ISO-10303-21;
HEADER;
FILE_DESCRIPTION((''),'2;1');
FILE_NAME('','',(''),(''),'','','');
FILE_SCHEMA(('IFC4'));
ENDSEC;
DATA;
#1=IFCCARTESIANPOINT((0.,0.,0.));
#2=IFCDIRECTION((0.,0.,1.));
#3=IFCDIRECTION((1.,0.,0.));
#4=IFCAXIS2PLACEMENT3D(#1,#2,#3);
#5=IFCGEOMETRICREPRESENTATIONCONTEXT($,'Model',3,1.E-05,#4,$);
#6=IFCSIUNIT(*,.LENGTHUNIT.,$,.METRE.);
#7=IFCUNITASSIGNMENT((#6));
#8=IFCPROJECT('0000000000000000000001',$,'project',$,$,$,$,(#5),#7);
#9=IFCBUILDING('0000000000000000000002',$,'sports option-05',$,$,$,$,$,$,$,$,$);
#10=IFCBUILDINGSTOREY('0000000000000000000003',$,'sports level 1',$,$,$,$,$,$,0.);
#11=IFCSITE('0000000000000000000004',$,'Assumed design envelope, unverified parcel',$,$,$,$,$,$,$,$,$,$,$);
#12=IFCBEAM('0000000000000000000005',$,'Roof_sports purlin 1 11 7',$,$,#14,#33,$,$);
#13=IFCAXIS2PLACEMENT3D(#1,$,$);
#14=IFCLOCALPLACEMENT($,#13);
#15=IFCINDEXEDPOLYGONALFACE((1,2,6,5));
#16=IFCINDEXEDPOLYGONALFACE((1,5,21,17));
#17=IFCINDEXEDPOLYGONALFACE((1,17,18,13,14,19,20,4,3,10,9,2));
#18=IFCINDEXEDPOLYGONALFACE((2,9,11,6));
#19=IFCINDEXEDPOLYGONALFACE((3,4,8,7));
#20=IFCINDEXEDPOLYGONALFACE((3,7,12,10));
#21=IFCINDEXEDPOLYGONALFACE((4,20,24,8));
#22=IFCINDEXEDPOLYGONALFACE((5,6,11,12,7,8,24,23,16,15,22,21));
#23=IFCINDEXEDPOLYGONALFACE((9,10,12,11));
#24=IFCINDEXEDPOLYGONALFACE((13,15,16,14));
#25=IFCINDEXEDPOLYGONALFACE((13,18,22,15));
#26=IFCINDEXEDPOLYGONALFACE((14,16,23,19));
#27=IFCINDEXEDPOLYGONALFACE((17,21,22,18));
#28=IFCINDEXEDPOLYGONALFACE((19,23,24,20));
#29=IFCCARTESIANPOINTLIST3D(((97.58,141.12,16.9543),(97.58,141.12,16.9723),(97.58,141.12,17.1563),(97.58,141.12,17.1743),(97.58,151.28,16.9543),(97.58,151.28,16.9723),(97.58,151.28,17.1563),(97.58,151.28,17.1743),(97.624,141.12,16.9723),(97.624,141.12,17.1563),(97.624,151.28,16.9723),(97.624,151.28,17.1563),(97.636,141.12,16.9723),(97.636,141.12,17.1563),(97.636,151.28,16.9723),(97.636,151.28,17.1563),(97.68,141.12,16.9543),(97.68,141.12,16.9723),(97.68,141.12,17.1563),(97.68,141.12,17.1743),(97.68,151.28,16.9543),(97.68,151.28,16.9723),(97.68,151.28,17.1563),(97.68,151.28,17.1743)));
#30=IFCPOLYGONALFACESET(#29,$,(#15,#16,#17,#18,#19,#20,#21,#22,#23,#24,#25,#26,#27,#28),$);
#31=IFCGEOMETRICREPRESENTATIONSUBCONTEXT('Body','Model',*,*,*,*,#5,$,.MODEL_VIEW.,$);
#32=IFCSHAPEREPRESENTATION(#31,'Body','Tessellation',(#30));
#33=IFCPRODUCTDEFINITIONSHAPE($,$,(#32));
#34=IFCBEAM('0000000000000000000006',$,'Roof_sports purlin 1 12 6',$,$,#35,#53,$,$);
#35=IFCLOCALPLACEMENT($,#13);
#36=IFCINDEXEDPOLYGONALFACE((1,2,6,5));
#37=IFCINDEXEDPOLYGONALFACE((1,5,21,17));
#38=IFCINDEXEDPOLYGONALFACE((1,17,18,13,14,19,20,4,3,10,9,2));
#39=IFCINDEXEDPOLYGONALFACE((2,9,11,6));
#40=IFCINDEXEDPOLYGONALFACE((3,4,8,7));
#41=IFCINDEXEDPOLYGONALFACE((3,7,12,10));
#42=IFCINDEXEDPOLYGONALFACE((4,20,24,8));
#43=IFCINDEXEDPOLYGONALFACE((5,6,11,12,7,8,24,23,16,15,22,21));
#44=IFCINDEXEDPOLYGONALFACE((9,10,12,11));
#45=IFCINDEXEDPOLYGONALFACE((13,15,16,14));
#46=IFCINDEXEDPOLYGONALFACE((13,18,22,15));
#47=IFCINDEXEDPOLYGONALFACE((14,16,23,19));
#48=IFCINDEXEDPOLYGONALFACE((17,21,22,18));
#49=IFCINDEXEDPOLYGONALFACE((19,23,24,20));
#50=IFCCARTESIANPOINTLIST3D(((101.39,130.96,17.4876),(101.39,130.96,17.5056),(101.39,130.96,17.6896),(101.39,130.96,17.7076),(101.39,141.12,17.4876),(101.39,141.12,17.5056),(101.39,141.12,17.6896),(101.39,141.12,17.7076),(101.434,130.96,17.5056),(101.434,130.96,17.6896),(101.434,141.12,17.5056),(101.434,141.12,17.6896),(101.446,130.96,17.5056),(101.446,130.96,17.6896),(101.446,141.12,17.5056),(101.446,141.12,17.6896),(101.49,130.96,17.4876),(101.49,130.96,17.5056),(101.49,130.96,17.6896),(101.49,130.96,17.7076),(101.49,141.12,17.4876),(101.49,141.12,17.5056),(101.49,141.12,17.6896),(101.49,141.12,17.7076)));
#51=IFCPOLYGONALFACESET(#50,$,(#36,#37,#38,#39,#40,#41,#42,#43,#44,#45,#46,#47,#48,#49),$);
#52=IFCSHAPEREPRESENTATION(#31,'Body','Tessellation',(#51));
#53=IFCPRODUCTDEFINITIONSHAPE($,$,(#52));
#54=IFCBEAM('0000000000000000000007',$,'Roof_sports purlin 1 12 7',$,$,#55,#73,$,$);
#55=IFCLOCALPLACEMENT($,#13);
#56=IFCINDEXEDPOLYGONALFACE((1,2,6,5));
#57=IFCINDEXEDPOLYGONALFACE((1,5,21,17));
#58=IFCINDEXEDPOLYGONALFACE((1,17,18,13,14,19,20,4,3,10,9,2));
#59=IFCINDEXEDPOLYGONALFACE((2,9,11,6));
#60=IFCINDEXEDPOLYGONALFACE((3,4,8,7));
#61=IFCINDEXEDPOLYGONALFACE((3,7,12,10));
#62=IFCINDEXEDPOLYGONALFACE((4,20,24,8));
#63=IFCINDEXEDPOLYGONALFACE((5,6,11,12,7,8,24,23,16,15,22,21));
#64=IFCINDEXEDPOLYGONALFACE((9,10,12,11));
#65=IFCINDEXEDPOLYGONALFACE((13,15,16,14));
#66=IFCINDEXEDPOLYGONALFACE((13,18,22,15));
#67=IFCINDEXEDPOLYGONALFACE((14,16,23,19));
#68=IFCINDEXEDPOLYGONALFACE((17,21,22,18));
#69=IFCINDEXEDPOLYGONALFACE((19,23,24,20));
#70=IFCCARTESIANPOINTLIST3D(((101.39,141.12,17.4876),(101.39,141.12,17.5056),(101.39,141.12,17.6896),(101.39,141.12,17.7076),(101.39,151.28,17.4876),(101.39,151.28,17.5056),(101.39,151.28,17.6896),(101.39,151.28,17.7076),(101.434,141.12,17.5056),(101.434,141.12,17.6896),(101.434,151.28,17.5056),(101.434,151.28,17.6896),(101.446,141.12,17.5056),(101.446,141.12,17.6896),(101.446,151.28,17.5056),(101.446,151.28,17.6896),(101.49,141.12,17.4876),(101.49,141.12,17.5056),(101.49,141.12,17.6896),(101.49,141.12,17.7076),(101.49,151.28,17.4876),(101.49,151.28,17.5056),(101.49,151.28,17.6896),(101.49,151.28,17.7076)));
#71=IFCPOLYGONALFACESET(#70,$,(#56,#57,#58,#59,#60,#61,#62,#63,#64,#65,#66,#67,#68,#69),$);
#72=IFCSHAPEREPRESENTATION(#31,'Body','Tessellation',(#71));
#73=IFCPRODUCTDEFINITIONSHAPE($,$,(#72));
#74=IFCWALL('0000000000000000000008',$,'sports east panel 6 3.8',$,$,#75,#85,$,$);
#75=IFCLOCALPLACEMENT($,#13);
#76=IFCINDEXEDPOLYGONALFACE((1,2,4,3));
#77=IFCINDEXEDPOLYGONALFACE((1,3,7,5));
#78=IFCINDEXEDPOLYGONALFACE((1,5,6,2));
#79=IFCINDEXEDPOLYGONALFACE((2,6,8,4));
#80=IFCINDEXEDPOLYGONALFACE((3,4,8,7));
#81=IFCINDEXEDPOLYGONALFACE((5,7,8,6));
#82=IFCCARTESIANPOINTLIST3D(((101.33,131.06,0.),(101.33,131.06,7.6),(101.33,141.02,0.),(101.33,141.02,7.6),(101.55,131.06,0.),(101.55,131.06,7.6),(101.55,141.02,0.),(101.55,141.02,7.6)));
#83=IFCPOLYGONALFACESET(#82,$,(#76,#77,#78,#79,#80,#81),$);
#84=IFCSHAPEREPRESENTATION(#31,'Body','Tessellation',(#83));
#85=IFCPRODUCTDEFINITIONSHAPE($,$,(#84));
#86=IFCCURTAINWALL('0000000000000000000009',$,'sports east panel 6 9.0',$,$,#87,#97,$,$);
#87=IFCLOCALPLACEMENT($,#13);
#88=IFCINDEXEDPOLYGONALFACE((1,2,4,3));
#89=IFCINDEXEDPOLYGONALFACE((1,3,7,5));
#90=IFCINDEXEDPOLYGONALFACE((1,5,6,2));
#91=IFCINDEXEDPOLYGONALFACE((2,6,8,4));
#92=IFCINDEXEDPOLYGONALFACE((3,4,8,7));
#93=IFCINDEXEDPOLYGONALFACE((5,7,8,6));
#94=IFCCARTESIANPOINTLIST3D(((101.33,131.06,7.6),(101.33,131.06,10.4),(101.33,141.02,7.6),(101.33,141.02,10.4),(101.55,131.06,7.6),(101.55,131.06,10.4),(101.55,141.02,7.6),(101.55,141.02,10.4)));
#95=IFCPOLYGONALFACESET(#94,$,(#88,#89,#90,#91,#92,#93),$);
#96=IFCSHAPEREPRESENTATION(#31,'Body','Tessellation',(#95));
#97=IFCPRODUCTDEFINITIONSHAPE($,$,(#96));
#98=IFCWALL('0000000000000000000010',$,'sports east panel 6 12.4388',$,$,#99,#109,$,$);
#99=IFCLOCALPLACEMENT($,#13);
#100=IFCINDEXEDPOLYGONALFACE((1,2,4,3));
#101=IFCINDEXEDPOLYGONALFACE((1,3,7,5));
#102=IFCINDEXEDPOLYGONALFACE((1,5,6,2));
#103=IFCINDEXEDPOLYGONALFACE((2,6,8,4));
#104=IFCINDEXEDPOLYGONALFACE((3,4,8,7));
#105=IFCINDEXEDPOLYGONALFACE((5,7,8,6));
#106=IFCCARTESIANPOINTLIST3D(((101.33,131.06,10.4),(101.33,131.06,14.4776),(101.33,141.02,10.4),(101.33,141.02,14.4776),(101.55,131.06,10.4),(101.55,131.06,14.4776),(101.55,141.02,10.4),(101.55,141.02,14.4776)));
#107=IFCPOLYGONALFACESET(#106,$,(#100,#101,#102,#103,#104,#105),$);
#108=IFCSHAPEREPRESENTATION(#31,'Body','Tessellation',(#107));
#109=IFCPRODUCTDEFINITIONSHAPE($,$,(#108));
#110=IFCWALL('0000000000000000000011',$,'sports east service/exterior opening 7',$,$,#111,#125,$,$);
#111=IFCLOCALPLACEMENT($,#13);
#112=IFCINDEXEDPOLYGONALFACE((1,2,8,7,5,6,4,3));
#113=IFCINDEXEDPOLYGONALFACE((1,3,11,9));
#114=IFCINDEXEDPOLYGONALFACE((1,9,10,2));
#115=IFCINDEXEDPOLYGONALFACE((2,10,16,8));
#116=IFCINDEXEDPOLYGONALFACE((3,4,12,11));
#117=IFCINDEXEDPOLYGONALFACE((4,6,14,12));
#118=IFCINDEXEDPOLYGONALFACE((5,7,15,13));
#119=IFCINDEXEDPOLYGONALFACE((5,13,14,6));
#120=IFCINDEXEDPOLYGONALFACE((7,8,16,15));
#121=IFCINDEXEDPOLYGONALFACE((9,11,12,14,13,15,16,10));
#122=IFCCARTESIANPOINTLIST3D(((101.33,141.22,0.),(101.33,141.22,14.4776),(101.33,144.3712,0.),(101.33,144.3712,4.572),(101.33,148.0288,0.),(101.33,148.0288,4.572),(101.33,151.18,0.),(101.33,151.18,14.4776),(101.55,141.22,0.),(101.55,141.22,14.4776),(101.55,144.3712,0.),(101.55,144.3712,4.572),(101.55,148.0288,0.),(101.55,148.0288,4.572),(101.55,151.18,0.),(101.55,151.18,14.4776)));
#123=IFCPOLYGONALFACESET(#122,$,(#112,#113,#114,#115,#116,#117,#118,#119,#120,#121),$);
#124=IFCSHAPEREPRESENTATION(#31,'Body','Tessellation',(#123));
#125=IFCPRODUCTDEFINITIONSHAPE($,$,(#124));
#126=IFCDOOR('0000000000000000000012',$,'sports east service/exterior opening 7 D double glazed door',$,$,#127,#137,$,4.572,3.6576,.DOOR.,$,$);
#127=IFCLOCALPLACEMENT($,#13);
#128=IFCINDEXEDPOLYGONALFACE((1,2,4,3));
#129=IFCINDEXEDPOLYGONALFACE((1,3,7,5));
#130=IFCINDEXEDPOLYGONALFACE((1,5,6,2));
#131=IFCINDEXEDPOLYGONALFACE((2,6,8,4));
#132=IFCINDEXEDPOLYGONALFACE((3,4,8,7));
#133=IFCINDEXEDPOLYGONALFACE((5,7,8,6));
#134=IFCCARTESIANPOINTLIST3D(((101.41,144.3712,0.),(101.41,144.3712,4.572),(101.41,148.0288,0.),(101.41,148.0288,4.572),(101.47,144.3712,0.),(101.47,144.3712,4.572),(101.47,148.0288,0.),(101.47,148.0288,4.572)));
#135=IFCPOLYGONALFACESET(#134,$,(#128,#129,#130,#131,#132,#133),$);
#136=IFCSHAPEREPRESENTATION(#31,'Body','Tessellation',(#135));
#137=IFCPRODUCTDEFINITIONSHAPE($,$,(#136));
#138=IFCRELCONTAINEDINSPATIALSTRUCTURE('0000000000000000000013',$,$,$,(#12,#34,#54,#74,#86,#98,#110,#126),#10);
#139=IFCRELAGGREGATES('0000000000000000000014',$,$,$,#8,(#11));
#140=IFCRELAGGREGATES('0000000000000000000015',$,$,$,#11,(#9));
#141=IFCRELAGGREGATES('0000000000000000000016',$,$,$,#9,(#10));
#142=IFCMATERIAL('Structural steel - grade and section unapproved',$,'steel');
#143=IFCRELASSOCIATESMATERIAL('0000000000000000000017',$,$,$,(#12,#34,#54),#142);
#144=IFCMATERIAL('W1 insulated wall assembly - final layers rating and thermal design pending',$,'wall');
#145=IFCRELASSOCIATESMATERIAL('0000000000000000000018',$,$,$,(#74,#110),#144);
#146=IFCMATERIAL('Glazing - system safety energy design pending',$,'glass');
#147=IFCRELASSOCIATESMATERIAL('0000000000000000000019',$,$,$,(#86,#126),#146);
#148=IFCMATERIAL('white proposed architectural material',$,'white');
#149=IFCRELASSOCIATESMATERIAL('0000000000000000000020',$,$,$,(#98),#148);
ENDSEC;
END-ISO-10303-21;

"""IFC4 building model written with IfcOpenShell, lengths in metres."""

from ifc_helpers import new_model, si_unit, frame, origin_with_axes, place, context, subcontext, project, spatial, rectangle, i_section, extrude, material, element, fill, save


model = new_model("IFC4")

# Units and contexts
model_context = context("Model", 3, precision=1e-05, world=origin_with_axes())
body_context = subcontext(model_context, "Body", "Model", "MODEL_VIEW")
ifc_project = project(units=[si_unit("LENGTHUNIT", "METRE")], contexts=[model_context])

# Site, building, storey
site = spatial("IfcSite", under=ifc_project, Name="Assumed design envelope, unverified parcel")
building = spatial("IfcBuilding", under=site, Name="sports option-05")
storey = spatial("IfcBuildingStorey", under=building, Name="sports level 1", Elevation=0.0)

# Shared definitions
ifc_material_1 = material(Name="Structural steel - grade and section unapproved", Category="steel")

# Beams
beam_1_placement = place(None, frame((97.63, 141.12, 17.0643), z_axis=(0.0, 1.0, 0.0), x_axis=(-1.0, 0.0, 0.0)))
element("IfcBeam", 1, at=beam_1_placement, inside=storey, material=ifc_material_1, Name="Roof_sports purlin 1 11 7", context=body_context, shape_type="SweptSolid", body=[
    extrude(i_section(OverallWidth=0.1, OverallDepth=0.22, WebThickness=0.012, FlangeThickness=0.018, FilletRadius=0.0), origin_with_axes(), (0.0, 0.0, 1.0), 10.16),
])
beam_2_placement = place(None, frame((101.44, 130.96, 17.5976), z_axis=(0.0, 1.0, 0.0), x_axis=(-1.0, 0.0, 0.0)))
element("IfcBeam", 2, at=beam_2_placement, inside=storey, material=ifc_material_1, Name="Roof_sports purlin 1 12 6", context=body_context, shape_type="SweptSolid", body=[
    extrude(i_section(OverallWidth=0.1, OverallDepth=0.22, WebThickness=0.012, FlangeThickness=0.018, FilletRadius=0.0), origin_with_axes(), (0.0, 0.0, 1.0), 10.16),
])
beam_3_placement = place(None, frame((101.44, 141.12, 17.5976), z_axis=(0.0, 1.0, 0.0), x_axis=(-1.0, 0.0, 0.0)))
element("IfcBeam", 3, at=beam_3_placement, inside=storey, material=ifc_material_1, Name="Roof_sports purlin 1 12 7", context=body_context, shape_type="SweptSolid", body=[
    extrude(i_section(OverallWidth=0.1, OverallDepth=0.22, WebThickness=0.012, FlangeThickness=0.018, FilletRadius=0.0), origin_with_axes(), (0.0, 0.0, 1.0), 10.16),
])

# Wall
ifc_material_2 = material(Name="W1 insulated wall assembly - final layers rating and thermal design pending", Category="wall")
wall_1_placement = place(None, frame((101.44, 136.04, 0.0), z_axis=(0.0, 0.0, 1.0), x_axis=(1.0, 0.0, 0.0)))
element("IfcWall", 4, at=wall_1_placement, inside=storey, material=ifc_material_2, Name="sports east panel 6 3.8", context=body_context, shape_type="SweptSolid", body=[
    extrude(rectangle(XDim=0.22, YDim=9.96), origin_with_axes(), (0.0, 0.0, 1.0), 7.6),
])

# Curtain wall
ifc_material_3 = material(Name="Glazing - system safety energy design pending", Category="glass")
curtain_wall_placement = place(None, frame((101.44, 136.04, 7.6), z_axis=(0.0, 0.0, 1.0), x_axis=(1.0, 0.0, 0.0)))
element("IfcCurtainWall", 5, at=curtain_wall_placement, inside=storey, material=ifc_material_3, Name="sports east panel 6 9.0", context=body_context, shape_type="SweptSolid", body=[
    extrude(rectangle(XDim=0.22, YDim=9.96), origin_with_axes(), (0.0, 0.0, 1.0), 2.8),
])

# Wall
ifc_material_4 = material(Name="white proposed architectural material", Category="white")
wall_2_placement = place(None, frame((101.44, 136.04, 10.4), z_axis=(0.0, 0.0, 1.0), x_axis=(1.0, 0.0, 0.0)))
element("IfcWall", 6, at=wall_2_placement, inside=storey, material=ifc_material_4, Name="sports east panel 6 12.4388", context=body_context, shape_type="SweptSolid", body=[
    extrude(rectangle(XDim=0.22, YDim=9.96), origin_with_axes(), (0.0, 0.0, 1.0), 4.0776),
])

# Wall, opening, door
wall_3_placement = place(None, frame((101.44, 146.2, 0.0), z_axis=(0.0, 0.0, 1.0), x_axis=(0.0, 1.0, 0.0)))
wall_3 = element("IfcWall", 7, at=wall_3_placement, inside=storey, material=ifc_material_2, Name="sports east service/exterior opening 7", context=body_context, shape_type="SweptSolid", body=[
    extrude(rectangle(XDim=9.96, YDim=0.22), origin_with_axes(), (0.0, 0.0, 1.0), 14.4776),
])
opening_placement = place(None, frame((101.44, 146.2, 0.0), z_axis=(0.0, 0.0, 1.0), x_axis=(0.0, 1.0, 0.0)))
opening = element("IfcOpeningElement", 8, at=opening_placement, cuts=wall_3, context=body_context, shape_type="SweptSolid", body=[
    extrude(rectangle(XDim=3.6576, YDim=0.32), origin_with_axes(), (0.0, 0.0, 1.0), 4.572),
])
door_placement = place(None, frame((101.44, 146.2, 0.0), z_axis=(0.0, 0.0, 1.0), x_axis=(0.0, 1.0, 0.0)))
door = element("IfcDoor", 9, at=door_placement, inside=storey, material=ifc_material_3, Name="sports east service/exterior opening 7 D double glazed door", OverallHeight=4.572, OverallWidth=3.6576, PredefinedType="DOOR", context=body_context, shape_type="SweptSolid", body=[
    extrude(rectangle(XDim=3.6576, YDim=0.06), origin_with_axes(), (0.0, 0.0, 1.0), 4.572),
])
fill(opening, door)

save(model, "model.ifc")
